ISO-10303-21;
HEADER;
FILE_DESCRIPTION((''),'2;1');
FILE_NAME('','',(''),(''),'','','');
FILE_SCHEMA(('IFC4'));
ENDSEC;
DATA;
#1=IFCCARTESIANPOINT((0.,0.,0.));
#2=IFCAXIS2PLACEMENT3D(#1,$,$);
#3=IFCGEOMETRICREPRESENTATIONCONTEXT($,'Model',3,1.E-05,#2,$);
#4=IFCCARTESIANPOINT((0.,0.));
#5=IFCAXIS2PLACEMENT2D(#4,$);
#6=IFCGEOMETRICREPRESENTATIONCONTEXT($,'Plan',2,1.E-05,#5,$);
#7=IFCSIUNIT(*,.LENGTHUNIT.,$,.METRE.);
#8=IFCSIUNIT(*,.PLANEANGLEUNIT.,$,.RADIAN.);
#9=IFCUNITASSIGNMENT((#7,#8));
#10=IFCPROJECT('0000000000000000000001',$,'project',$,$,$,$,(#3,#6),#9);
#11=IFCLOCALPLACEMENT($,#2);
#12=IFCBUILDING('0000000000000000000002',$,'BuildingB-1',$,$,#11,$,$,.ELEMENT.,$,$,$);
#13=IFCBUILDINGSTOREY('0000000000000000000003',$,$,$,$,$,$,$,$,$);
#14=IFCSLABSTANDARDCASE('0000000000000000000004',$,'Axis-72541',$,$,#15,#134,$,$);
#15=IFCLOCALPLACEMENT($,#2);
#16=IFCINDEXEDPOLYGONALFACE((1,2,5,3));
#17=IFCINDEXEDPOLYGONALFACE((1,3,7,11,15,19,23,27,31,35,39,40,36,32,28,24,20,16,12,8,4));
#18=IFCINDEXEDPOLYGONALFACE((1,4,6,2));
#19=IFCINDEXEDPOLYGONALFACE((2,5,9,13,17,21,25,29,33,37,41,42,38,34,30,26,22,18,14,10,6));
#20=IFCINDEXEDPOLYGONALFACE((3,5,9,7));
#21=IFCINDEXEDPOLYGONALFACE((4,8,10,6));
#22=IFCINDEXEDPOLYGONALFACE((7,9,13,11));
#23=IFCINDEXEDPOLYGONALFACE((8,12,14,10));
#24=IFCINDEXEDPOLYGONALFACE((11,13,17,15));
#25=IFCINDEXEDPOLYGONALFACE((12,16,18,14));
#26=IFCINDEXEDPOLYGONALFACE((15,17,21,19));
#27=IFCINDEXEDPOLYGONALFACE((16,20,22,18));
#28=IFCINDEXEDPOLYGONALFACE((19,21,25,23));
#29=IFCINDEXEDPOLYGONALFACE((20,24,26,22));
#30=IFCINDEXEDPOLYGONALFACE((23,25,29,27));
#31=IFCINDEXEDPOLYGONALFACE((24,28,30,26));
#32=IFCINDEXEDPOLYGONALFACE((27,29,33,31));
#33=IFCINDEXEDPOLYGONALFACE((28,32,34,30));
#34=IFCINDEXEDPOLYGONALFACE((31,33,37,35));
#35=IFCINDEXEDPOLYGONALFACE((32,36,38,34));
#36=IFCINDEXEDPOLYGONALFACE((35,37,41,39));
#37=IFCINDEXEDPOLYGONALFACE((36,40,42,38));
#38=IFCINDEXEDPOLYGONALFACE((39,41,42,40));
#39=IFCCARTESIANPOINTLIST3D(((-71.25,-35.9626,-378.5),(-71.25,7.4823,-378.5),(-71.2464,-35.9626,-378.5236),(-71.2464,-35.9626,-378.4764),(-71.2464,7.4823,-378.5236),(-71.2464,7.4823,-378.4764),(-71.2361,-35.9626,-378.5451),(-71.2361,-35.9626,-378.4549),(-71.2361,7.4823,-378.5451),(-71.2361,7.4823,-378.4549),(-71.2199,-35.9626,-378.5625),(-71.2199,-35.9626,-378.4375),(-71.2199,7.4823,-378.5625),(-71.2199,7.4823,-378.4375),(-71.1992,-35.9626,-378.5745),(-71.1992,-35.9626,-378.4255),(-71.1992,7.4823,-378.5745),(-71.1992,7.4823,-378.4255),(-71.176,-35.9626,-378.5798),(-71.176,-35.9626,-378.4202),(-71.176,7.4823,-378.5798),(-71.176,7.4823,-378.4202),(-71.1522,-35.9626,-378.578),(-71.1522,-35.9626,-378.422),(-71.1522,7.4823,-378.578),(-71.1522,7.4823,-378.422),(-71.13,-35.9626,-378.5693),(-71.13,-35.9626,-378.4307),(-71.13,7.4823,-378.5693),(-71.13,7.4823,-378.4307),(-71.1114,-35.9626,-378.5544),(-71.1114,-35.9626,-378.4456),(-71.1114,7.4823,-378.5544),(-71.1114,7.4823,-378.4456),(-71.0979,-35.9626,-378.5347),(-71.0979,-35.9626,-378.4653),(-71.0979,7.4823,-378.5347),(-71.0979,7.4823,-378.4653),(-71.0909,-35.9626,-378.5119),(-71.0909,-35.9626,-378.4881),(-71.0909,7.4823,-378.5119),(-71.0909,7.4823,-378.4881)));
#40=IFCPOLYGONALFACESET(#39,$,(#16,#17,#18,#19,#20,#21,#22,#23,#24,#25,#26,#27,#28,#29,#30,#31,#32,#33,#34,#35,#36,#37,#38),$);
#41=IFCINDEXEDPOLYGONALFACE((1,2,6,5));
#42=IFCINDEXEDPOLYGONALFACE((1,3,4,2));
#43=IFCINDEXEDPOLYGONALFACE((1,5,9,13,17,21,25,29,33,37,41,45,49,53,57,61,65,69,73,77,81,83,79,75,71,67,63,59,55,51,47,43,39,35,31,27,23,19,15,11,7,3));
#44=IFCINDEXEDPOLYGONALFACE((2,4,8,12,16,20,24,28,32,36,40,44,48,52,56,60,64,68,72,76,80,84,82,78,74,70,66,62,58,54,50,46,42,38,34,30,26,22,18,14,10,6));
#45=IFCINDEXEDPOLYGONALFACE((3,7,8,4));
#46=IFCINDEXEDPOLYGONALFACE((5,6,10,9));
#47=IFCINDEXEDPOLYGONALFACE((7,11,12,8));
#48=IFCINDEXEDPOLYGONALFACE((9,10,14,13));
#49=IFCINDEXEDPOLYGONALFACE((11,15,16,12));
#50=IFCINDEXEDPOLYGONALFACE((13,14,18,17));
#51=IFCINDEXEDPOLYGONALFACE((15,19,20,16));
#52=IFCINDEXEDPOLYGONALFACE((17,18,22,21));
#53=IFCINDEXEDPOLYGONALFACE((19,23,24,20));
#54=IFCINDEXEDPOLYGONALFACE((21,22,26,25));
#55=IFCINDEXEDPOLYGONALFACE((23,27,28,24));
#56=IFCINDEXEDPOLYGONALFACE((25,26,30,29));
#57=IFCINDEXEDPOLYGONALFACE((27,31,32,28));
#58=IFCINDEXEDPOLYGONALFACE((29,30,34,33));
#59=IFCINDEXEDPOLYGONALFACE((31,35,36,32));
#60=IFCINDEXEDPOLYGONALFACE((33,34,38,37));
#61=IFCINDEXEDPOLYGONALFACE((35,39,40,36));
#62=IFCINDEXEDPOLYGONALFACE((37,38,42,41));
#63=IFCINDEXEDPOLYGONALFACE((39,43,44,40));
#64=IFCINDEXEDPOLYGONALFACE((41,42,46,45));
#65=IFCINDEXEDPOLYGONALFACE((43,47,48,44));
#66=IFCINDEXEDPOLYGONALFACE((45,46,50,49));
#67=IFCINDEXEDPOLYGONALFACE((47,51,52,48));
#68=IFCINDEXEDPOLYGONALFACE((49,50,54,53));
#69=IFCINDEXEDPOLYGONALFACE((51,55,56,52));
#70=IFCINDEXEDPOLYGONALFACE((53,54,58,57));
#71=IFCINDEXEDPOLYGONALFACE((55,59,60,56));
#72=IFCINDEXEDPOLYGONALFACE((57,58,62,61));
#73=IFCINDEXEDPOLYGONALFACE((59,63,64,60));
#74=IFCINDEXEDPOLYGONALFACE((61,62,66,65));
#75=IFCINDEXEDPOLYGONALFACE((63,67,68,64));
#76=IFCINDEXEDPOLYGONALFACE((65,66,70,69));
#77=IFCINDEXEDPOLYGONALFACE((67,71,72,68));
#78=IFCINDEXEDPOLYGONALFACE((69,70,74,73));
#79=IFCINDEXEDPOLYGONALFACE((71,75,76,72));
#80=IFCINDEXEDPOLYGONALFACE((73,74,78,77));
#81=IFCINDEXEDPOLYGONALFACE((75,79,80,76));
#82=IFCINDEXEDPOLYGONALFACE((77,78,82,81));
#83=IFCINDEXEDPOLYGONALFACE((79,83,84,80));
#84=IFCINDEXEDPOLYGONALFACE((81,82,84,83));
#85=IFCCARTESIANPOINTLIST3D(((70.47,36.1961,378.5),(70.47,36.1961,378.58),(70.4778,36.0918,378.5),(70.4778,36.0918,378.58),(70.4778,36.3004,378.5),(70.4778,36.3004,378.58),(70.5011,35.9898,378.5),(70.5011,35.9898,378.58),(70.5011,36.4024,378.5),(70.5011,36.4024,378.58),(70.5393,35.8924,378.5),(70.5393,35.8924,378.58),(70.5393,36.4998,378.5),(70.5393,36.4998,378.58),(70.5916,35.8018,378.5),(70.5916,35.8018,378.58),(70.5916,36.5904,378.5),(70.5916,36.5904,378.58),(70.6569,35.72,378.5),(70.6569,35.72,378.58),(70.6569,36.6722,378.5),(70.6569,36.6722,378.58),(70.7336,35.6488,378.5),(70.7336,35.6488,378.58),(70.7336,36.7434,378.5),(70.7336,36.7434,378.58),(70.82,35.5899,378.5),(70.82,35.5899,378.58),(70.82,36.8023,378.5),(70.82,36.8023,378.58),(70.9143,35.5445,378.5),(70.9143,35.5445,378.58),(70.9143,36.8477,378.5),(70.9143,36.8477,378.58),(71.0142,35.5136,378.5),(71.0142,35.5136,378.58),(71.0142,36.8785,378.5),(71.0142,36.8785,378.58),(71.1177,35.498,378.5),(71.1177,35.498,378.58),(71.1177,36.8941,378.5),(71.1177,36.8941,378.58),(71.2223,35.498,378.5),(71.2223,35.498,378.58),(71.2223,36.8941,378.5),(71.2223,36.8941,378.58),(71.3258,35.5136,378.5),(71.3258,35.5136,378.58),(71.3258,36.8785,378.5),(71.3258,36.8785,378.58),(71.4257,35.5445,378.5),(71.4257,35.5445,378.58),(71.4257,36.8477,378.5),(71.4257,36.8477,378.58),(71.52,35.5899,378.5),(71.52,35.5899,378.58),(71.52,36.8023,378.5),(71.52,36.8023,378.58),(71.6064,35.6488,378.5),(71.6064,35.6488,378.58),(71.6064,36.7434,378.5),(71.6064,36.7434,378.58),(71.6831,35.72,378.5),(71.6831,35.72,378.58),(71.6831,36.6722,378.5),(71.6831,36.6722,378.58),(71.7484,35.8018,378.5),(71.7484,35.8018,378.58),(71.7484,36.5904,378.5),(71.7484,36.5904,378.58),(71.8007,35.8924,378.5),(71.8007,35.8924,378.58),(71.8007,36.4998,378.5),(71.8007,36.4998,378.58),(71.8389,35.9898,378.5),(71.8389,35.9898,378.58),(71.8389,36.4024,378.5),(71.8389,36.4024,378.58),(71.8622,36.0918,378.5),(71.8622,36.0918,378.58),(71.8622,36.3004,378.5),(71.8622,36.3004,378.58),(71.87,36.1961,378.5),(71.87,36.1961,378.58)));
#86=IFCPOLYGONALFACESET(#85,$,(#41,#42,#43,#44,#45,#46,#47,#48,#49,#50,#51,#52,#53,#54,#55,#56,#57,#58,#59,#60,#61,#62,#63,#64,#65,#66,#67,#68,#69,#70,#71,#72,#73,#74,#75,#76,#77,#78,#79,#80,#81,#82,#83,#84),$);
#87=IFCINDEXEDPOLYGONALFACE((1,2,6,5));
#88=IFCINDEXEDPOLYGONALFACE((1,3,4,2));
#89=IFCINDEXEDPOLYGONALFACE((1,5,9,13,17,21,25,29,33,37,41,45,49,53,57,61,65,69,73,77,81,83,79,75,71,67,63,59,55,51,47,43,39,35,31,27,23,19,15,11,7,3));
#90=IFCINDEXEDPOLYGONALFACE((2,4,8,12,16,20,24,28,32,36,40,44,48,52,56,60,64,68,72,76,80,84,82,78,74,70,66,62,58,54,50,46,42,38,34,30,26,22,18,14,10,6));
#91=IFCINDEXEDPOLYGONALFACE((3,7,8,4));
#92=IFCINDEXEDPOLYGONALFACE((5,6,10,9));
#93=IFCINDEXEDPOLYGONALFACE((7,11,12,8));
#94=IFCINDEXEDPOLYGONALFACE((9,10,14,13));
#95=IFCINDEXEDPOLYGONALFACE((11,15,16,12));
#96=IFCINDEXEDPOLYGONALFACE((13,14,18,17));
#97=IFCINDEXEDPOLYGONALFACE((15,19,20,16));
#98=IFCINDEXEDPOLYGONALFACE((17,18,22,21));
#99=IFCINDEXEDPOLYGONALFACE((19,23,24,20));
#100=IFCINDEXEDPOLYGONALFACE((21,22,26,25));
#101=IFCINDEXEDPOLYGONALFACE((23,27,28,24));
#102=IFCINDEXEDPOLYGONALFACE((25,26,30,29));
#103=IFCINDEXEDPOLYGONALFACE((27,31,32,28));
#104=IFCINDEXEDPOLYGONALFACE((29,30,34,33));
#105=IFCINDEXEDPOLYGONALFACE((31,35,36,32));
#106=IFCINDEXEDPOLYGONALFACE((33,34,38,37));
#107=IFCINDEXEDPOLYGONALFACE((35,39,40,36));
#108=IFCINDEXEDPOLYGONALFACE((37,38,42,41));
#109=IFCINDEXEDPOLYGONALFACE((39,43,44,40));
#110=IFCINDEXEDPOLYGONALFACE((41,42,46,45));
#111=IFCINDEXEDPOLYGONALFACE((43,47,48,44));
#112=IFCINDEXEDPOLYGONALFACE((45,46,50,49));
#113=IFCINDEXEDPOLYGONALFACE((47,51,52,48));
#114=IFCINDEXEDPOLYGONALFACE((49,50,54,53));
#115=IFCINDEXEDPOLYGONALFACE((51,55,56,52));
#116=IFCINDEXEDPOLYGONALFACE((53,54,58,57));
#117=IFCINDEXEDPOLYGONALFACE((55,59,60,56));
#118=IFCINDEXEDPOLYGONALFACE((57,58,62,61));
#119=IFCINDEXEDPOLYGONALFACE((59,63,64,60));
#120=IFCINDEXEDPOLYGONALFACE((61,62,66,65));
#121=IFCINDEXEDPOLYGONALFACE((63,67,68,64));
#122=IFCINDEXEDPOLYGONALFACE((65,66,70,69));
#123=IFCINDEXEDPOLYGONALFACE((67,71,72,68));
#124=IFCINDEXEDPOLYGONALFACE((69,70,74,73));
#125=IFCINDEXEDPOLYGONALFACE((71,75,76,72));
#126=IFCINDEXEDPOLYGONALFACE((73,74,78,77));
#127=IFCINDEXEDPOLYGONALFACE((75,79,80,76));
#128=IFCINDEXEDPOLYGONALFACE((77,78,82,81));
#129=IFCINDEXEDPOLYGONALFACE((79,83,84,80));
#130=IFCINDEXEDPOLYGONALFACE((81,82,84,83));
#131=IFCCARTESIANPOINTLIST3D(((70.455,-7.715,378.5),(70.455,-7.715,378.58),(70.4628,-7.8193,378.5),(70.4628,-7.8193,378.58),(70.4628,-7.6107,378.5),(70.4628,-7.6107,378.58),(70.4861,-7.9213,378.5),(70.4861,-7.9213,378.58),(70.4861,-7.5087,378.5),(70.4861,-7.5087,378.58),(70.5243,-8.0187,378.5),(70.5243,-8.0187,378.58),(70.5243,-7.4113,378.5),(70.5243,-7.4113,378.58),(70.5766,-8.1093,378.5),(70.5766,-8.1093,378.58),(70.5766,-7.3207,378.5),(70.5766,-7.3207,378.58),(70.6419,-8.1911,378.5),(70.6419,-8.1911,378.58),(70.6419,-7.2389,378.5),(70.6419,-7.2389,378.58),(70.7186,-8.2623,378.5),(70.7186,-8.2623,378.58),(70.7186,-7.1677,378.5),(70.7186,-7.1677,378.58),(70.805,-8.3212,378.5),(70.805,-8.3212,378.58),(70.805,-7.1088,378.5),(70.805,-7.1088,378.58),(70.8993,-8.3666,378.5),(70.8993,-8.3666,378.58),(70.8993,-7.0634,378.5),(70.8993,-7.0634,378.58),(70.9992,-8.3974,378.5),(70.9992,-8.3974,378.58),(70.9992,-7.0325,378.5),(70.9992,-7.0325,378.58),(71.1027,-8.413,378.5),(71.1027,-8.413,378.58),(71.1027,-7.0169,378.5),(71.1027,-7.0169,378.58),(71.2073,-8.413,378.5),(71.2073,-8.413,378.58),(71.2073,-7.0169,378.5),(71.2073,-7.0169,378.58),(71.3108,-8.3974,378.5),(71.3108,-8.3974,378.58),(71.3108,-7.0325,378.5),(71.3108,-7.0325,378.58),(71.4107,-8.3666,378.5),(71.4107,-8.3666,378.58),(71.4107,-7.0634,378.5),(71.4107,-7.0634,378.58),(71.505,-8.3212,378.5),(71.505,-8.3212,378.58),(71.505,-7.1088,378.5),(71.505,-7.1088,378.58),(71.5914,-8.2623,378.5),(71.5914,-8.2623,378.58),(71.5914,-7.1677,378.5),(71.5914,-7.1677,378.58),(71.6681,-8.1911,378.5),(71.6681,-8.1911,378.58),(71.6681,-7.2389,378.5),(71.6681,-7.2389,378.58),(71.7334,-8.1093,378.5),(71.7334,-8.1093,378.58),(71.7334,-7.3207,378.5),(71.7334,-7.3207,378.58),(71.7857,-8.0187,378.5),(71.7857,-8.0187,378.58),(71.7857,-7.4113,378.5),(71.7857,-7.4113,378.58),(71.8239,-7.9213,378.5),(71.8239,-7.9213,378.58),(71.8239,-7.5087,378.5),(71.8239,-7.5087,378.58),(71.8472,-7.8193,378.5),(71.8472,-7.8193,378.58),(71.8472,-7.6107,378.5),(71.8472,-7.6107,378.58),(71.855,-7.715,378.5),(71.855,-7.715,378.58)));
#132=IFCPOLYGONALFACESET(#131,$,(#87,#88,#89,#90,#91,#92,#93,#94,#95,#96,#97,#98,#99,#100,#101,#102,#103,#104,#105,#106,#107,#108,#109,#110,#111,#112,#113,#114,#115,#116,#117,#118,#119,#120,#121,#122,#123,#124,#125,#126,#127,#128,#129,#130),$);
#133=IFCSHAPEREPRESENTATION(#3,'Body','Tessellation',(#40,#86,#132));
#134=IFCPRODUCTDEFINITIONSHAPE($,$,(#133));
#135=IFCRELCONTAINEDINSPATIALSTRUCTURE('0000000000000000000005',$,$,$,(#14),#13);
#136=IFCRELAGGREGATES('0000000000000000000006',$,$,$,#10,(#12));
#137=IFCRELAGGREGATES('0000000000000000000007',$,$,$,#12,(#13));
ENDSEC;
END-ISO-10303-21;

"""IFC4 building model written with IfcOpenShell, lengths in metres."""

from ifc_helpers import new_model, entity, si_unit, frame, origin, origin_2d, place, context, project, spatial, circle, extrude, element, save


model = new_model("IFC4")

# Units and contexts
model_context = context("Model", 3, precision=1e-05, world=origin())
plan_context = context("Plan", 2, precision=1e-05, world=origin_2d())
ifc_project = project(units=[si_unit("LENGTHUNIT", "METRE"), si_unit("PLANEANGLEUNIT", "RADIAN")], contexts=[model_context, plan_context])

# Building, storey
building_placement = place(None, origin())
building = spatial("IfcBuilding", under=ifc_project, at=building_placement, Name="BuildingB-1", CompositionType="ELEMENT")
storey = spatial("IfcBuildingStorey", under=building)

# Slab
element("IfcSlabStandardCase", 1, inside=storey, Name="Axis-72541", context=model_context, shape_type="AdvancedSweptSolid", body=[
    entity("IfcSurfaceCurveSweptAreaSolid", entity("IfcCircleProfileDef", "AREA", None, None, 0.08), None, entity("IfcPolyline", [entity("IfcCartesianPoint", [71.17, 35.9626, 378.5]), entity("IfcCartesianPoint", [71.17, -7.4823, 378.5])]), None, None, entity("IfcPlane", entity("IfcAxis2Placement3D", entity("IfcCartesianPoint", [71.17, 35.9626, 378.5]), entity("IfcDirection", [0.0, 0.0, 1.0]), entity("IfcDirection", [1.0, 0.0, 0.0])))),
    extrude(circle(Radius=0.7), frame((71.17, 36.1961, 378.5)), (0.0, 0.0, 1.0), 0.08),
    extrude(circle(Radius=0.7), frame((71.155, -7.715, 378.5)), (0.0, 0.0, 1.0), 0.08),
])

save(model, "model.ifc")
